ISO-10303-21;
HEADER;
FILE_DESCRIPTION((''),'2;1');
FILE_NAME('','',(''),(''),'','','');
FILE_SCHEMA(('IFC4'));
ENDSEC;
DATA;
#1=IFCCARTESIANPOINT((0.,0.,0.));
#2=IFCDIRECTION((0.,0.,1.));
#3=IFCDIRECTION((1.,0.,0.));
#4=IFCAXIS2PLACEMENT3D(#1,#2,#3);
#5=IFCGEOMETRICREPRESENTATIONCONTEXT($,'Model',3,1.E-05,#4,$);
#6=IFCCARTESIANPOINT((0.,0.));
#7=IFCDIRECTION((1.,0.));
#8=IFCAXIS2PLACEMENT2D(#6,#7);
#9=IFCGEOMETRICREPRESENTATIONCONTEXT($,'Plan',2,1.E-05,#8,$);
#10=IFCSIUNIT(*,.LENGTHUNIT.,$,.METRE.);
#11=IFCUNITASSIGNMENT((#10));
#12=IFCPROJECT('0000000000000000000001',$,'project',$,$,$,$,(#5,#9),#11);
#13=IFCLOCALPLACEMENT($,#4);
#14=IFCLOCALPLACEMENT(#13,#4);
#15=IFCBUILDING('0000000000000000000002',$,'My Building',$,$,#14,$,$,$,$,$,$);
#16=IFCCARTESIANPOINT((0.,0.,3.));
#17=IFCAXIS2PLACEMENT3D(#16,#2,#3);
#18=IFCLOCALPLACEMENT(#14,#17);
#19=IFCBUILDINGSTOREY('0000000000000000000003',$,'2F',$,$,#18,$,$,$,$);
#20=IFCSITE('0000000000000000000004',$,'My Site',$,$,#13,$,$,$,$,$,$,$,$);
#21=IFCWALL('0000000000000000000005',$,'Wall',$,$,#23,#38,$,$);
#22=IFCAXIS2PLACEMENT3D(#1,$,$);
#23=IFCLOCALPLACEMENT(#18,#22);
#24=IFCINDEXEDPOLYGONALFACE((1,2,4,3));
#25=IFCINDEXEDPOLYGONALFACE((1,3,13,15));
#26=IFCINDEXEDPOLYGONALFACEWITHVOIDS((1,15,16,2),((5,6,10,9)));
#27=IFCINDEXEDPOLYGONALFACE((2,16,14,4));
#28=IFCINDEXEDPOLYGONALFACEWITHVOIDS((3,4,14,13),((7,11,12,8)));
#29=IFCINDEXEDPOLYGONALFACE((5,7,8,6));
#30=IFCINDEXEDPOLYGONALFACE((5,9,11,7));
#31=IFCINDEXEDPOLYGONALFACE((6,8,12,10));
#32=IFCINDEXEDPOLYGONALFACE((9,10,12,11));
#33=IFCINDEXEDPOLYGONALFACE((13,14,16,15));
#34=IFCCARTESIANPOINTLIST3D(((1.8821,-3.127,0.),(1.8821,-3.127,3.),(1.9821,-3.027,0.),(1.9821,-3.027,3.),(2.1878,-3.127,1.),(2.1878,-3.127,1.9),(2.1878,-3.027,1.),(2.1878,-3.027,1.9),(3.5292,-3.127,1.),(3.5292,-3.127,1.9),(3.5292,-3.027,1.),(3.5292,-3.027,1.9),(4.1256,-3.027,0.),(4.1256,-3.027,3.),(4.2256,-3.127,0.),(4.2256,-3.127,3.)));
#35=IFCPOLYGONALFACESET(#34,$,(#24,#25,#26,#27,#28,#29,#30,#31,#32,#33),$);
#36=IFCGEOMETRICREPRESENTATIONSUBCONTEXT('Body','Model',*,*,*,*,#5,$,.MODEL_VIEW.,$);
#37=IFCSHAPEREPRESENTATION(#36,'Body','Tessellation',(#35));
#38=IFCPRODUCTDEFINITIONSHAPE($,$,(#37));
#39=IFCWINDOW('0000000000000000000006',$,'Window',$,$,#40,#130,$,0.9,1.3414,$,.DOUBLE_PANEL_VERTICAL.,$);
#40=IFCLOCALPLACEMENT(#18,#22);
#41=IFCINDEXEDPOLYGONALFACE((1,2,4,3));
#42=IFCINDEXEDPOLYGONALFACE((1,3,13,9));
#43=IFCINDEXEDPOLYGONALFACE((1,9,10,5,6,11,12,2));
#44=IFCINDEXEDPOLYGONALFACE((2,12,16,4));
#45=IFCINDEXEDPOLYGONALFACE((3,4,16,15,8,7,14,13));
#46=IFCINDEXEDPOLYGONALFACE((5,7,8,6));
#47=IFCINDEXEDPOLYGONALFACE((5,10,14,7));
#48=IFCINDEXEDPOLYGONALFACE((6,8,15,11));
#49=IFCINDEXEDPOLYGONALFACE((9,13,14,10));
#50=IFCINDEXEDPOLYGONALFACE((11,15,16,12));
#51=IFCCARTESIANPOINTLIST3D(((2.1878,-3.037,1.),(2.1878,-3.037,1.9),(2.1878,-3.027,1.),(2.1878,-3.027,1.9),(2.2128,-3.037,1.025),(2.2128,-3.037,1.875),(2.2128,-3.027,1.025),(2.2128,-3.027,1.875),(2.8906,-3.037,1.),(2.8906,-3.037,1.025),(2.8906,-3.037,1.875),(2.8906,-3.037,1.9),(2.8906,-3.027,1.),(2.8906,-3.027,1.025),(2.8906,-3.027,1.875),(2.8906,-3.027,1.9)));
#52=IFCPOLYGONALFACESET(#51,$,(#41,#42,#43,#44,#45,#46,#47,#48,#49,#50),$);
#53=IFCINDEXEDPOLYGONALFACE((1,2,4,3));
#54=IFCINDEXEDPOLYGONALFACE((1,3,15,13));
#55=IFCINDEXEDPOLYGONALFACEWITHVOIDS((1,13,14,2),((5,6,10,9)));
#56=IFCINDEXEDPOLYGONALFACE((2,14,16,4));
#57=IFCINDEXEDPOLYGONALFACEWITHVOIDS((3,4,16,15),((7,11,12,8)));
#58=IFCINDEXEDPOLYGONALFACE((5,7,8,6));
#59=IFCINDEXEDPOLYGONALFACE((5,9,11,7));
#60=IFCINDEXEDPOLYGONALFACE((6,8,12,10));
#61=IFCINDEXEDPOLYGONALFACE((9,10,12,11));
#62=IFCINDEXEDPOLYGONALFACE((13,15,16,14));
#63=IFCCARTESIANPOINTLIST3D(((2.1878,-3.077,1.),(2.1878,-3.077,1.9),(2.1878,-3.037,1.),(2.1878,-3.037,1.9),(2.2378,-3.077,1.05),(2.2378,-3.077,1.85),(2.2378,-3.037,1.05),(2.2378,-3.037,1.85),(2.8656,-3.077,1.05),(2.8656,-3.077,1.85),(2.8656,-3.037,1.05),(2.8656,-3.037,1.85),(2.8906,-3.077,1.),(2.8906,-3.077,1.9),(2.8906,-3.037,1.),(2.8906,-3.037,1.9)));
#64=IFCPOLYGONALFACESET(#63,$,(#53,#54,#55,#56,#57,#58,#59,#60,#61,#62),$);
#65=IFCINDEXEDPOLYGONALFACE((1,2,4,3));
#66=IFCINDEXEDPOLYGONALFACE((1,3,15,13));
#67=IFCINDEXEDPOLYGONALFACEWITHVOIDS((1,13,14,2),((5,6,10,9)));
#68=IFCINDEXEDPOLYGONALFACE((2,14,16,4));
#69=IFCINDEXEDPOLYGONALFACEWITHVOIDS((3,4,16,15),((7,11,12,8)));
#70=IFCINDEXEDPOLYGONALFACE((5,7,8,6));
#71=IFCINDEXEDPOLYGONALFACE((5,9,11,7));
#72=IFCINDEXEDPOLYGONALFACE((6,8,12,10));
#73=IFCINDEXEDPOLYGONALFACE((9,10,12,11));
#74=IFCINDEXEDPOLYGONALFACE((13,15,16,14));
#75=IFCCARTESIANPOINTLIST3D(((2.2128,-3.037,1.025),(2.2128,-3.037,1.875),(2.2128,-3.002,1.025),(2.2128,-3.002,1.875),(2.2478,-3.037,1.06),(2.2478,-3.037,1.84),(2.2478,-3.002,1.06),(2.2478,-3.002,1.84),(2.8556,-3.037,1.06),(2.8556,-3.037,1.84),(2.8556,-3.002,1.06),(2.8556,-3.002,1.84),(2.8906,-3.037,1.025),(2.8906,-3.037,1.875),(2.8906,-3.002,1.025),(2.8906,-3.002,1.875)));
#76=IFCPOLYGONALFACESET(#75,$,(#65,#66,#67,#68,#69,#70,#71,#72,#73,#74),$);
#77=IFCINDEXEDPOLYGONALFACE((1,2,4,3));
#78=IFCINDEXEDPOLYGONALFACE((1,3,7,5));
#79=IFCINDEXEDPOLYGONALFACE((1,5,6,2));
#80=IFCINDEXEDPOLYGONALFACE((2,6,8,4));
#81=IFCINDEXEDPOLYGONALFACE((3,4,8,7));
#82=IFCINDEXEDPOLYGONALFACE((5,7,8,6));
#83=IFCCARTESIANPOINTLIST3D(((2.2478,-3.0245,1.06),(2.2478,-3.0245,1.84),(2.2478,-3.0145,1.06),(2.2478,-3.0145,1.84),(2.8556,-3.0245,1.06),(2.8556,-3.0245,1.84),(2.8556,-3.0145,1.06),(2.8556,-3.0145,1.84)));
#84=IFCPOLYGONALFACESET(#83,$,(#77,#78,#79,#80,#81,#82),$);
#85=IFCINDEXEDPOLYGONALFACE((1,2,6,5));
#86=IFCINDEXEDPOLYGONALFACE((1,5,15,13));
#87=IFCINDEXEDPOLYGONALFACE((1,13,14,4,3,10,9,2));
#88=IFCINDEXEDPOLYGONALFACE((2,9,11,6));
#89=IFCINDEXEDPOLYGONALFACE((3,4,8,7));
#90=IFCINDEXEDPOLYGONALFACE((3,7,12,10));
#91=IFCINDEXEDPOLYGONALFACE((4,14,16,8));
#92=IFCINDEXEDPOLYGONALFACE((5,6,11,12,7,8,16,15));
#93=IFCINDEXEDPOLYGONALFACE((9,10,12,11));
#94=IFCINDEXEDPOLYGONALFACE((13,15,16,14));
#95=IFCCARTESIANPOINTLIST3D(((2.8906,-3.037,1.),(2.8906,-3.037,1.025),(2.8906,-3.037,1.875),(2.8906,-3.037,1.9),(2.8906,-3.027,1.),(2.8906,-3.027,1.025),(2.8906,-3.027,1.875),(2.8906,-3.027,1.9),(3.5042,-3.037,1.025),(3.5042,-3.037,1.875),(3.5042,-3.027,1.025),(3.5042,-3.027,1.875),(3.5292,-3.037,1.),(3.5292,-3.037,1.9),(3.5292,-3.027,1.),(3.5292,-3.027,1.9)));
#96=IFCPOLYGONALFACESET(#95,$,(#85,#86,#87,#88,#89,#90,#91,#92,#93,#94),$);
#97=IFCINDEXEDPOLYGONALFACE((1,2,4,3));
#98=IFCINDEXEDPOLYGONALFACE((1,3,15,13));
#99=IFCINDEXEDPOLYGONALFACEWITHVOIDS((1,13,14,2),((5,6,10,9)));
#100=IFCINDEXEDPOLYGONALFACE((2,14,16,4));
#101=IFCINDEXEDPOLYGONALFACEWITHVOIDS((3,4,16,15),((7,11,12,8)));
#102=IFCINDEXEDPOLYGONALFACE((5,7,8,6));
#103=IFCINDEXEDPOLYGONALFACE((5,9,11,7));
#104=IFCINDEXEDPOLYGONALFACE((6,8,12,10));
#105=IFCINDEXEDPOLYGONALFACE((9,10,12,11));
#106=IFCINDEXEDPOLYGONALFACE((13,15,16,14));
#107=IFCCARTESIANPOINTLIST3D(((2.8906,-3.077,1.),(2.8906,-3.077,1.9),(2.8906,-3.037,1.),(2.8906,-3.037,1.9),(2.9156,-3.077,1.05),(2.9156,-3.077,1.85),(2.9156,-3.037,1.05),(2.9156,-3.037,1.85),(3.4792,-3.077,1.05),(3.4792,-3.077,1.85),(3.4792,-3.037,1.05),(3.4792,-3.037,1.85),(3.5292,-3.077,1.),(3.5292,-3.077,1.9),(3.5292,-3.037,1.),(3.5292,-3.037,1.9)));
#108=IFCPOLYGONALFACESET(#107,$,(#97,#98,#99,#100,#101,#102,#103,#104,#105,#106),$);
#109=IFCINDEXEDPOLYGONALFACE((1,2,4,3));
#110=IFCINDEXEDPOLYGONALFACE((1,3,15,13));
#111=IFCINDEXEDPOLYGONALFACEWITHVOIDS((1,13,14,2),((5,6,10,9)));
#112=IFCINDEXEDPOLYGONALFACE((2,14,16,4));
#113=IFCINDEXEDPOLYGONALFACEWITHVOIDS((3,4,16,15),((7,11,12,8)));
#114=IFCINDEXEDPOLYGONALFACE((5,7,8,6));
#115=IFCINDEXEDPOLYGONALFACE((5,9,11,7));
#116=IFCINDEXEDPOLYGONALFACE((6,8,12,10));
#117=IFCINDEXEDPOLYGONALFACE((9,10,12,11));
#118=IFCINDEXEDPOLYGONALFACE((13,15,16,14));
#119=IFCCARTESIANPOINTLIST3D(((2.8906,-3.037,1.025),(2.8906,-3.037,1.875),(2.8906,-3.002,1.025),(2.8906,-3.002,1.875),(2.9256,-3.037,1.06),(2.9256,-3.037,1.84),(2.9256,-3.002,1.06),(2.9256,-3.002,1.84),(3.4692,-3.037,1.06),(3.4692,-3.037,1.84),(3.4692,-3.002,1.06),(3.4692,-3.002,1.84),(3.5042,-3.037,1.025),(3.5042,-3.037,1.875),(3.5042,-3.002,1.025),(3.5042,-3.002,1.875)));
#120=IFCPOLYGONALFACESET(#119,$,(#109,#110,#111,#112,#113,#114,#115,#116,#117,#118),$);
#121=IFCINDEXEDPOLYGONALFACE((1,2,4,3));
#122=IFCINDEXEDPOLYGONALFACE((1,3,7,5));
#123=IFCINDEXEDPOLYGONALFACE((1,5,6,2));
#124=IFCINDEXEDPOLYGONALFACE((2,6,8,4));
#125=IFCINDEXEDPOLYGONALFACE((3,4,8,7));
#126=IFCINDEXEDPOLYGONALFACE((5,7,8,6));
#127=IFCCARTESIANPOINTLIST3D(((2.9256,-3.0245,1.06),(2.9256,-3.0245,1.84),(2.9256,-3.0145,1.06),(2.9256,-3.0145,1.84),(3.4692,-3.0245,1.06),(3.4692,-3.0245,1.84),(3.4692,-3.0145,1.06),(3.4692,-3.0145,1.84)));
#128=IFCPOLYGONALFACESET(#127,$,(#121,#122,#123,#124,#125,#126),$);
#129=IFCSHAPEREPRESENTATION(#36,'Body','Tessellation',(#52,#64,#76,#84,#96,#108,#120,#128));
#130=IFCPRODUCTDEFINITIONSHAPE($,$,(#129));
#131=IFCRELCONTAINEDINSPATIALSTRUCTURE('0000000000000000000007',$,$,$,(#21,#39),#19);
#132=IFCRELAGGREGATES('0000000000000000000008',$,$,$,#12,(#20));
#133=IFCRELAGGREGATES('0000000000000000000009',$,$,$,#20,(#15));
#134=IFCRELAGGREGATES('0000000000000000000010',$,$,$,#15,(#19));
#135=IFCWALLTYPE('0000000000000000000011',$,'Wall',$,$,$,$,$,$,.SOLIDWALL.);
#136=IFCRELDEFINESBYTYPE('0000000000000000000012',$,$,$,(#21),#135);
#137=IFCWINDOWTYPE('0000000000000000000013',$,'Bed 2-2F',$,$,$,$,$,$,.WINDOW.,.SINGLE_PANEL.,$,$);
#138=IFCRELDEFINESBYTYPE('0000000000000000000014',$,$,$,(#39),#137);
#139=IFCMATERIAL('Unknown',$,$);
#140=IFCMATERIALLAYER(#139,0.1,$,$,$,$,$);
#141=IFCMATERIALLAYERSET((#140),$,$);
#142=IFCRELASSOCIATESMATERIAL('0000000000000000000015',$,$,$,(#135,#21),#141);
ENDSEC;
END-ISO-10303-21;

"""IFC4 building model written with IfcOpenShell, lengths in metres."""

from ifc_helpers import new_model, entity, si_unit, frame, origin_with_axes, origin_2d_with_axis, place, context, subcontext, project, spatial, line, indexed_curve, outline, extrude, shape, source, transform, mapped, material, layer, layer_set, layer_usage, type_object, type_shapes, element, fill, save


model = new_model("IFC4")

# Units and contexts
model_context = context("Model", 3, precision=1e-05, world=origin_with_axes())
plan_context = context("Plan", 2, precision=1e-05, world=origin_2d_with_axis())
body_context_1 = subcontext(model_context, "Body", "Model", "MODEL_VIEW")
body_context_2 = subcontext(plan_context, "Body", "Plan", "PLAN_VIEW")
ifc_project = project(units=[si_unit("LENGTHUNIT", "METRE")], contexts=[model_context, plan_context])

# Site, building, storey
site_placement = place(None, origin_with_axes())
site = spatial("IfcSite", under=ifc_project, at=site_placement, Name="My Site")
building_placement = place(site_placement, origin_with_axes())
building = spatial("IfcBuilding", under=site, at=building_placement, Name="My Building")
storey_placement = place(building_placement, frame((0.0, 0.0, 3.0), z_axis=(0.0, 0.0, 1.0), x_axis=(1.0, 0.0, 0.0)))
storey = spatial("IfcBuildingStorey", under=building, at=storey_placement, Name="2F")

# Shared definitions
ifc_material = material(Name="Unknown")
ifc_layer = layer(ifc_material, 0.1)
ifc_layer_set = layer_set([ifc_layer])
wall_type = type_object("IfcWallType", Name="Wall", PredefinedType="SOLIDWALL", material=ifc_layer_set)

# Wall, opening, window
ifc_layer_usage_1 = layer_usage(ifc_layer_set, "AXIS2", "POSITIVE", 0.0)
wall_1_placement = place(storey_placement, frame((1.8821, -3.127, 0.0), z_axis=(0.0, 0.0, 1.0), x_axis=(1.0, 0.0, 0.0)))
wall_1 = element("IfcWall", 1, at=wall_1_placement, inside=storey, type_object=wall_type, material=ifc_layer_usage_1, Name="Wall", context=body_context_1, shape_type="SweptSolid", body=[
    extrude(outline(indexed_curve([(0.0, 0.0), (0.1, 0.1), (2.2435, 0.1), (2.3435, 0.0)], segments=[line(1, 2, 3, 4, 1)])), origin_with_axes(), (0.0, 0.0, 1.0), 3.0),
])
shared_shape_1 = source(origin_with_axes(), body_context_1, "Body", "SweptSolid", [
    extrude(outline(indexed_curve([(0.0, 0.0), (1.3414, 0.0), (1.3414, 0.9), (0.0, 0.9)], segments=[line(1, 2, 3, 4, 1)])), frame((0.0, -0.6, 0.0), z_axis=(0.0, -1.0, 0.0), x_axis=(1.0, 0.0, 0.0)), (0.0, 0.0, -1.0), 1.2),
])
opening_1_placement = place(wall_1_placement, frame((0.3057, 0.0, 1.0), z_axis=(0.0, 0.0, 1.0), x_axis=(1.0, 0.0, 0.0)))
opening_1 = element("IfcOpeningElement", 2, at=opening_1_placement, cuts=wall_1, PredefinedType="OPENING", context=body_context_1, shape_type="MappedRepresentation", body=[
    mapped(shared_shape_1, transform((0.0, 0.0, 0.0), x_axis=(1.0, 0.0, 0.0), y_axis=(0.0, 1.0, 0.0), z_axis=(0.0, 0.0, 1.0), scale=1.0)),
])
window_type_1 = type_object("IfcWindowType", Name="Bed 2-2F", PartitioningType="SINGLE_PANEL", PredefinedType="WINDOW")
shared_shape_2 = source(origin_with_axes(), body_context_1, "Body", "SweptSolid", [
    extrude(outline(indexed_curve([(0.7028, 0.0), (0.0, 0.0), (0.0, 0.9), (0.7028, 0.9), (0.7028, 0.875), (0.025, 0.875), (0.025, 0.025), (0.7028, 0.025)], segments=[line(1, 2, 3, 4, 5, 6, 7, 8, 1)])), frame((0.0, 0.09, 0.0), z_axis=(0.0, -1.0, 0.0), x_axis=(1.0, 0.0, 0.0)), (0.0, 0.0, -1.0), 0.01),
    extrude(outline(indexed_curve([(0.0, 0.0), (0.7028, 0.0), (0.7028, 0.9), (0.0, 0.9)], segments=[line(1, 2, 3, 4, 1)]), holes=[indexed_curve([(0.05, 0.05), (0.6778, 0.05), (0.6778, 0.85), (0.05, 0.85)], segments=[line(1, 2, 3, 4, 1)])]), frame((0.0, 0.05, 0.0), z_axis=(0.0, -1.0, 0.0), x_axis=(1.0, 0.0, 0.0)), (0.0, 0.0, -1.0), 0.04),
    extrude(outline(indexed_curve([(0.0, 0.0), (0.6778, 0.0), (0.6778, 0.85), (0.0, 0.85)], segments=[line(1, 2, 3, 4, 1)]), holes=[indexed_curve([(0.035, 0.035), (0.6428, 0.035), (0.6428, 0.815), (0.035, 0.815)], segments=[line(1, 2, 3, 4, 1)])]), frame((0.025, 0.09, 0.025), z_axis=(0.0, -1.0, 0.0), x_axis=(1.0, 0.0, 0.0)), (0.0, 0.0, -1.0), 0.035),
    extrude(outline(indexed_curve([(0.035, 0.035), (0.6428, 0.035), (0.6428, 0.815), (0.035, 0.815)], segments=[line(1, 2, 3, 4, 1)])), frame((0.025, 0.1025, 0.025), z_axis=(0.0, -1.0, 0.0), x_axis=(1.0, 0.0, 0.0)), (0.0, 0.0, -1.0), 0.01),
    extrude(outline(indexed_curve([(0.0, 0.9), (0.6386, 0.9), (0.6386, 0.0), (0.0, 0.0), (0.0, 0.025), (0.6136, 0.025), (0.6136, 0.875), (0.0, 0.875)], segments=[line(1, 2, 3, 4, 5, 6, 7, 8, 1)])), frame((0.7028, 0.09, 0.0), z_axis=(0.0, -1.0, 0.0), x_axis=(1.0, 0.0, 0.0)), (0.0, 0.0, -1.0), 0.01),
    extrude(outline(indexed_curve([(0.0, 0.0), (0.6386, 0.0), (0.6386, 0.9), (0.0, 0.9)], segments=[line(1, 2, 3, 4, 1)]), holes=[indexed_curve([(0.025, 0.05), (0.5886, 0.05), (0.5886, 0.85), (0.025, 0.85)], segments=[line(1, 2, 3, 4, 1)])]), frame((0.7028, 0.05, 0.0), z_axis=(0.0, -1.0, 0.0), x_axis=(1.0, 0.0, 0.0)), (0.0, 0.0, -1.0), 0.04),
    extrude(outline(indexed_curve([(0.0, 0.0), (0.6136, 0.0), (0.6136, 0.85), (0.0, 0.85)], segments=[line(1, 2, 3, 4, 1)]), holes=[indexed_curve([(0.035, 0.035), (0.5786, 0.035), (0.5786, 0.815), (0.035, 0.815)], segments=[line(1, 2, 3, 4, 1)])]), frame((0.7028, 0.09, 0.025), z_axis=(0.0, -1.0, 0.0), x_axis=(1.0, 0.0, 0.0)), (0.0, 0.0, -1.0), 0.035),
    extrude(outline(indexed_curve([(0.035, 0.035), (0.5786, 0.035), (0.5786, 0.815), (0.035, 0.815)], segments=[line(1, 2, 3, 4, 1)])), frame((0.7028, 0.1025, 0.025), z_axis=(0.0, -1.0, 0.0), x_axis=(1.0, 0.0, 0.0)), (0.0, 0.0, -1.0), 0.01),
])
shared_shape_3 = source(origin_with_axes(), body_context_2, "Body", "Curve2D", [
    entity("IfcIndexedPolyCurve", entity("IfcCartesianPointList2D", [[0.05, 0.05], [0.6778, 0.05]])),
    entity("IfcIndexedPolyCurve", entity("IfcCartesianPointList2D", [[0.0, 0.1], [0.025, 0.1], [0.025, 0.09], [0.05, 0.09], [0.05, 0.05], [0.0, 0.05]]), [entity("IfcLineIndex", [1, 2, 3, 4, 5, 6, 1])]),
    entity("IfcIndexedPolyCurve", entity("IfcCartesianPointList2D", [[0.7028, 0.1], [0.7028, 0.1], [0.7028, 0.09], [0.6778, 0.09], [0.6778, 0.05], [0.7028, 0.05]])),
    entity("IfcIndexedPolyCurve", entity("IfcCartesianPointList2D", [[0.025, 0.09], [0.06, 0.09], [0.06, 0.125], [0.025, 0.125]]), [entity("IfcLineIndex", [1, 2, 3, 4, 1])]),
    entity("IfcIndexedPolyCurve", entity("IfcCartesianPointList2D", [[0.7028, 0.09], [0.6678, 0.09], [0.6678, 0.125], [0.7028, 0.125]]), [entity("IfcLineIndex", [1, 2, 3, 4, 1])]),
    entity("IfcIndexedPolyCurve", entity("IfcCartesianPointList2D", [[0.06, 0.09], [0.6678, 0.09]])),
    entity("IfcIndexedPolyCurve", entity("IfcCartesianPointList2D", [[0.06, 0.125], [0.6678, 0.125]])),
    entity("IfcIndexedPolyCurve", entity("IfcCartesianPointList2D", [[0.06, 0.1075], [0.6678, 0.1075]])),
    entity("IfcIndexedPolyCurve", entity("IfcCartesianPointList2D", [[0.7278, 0.05], [1.2914, 0.05]])),
    entity("IfcIndexedPolyCurve", entity("IfcCartesianPointList2D", [[0.7028, 0.1], [0.7028, 0.1], [0.7028, 0.09], [0.7278, 0.09], [0.7278, 0.05], [0.7028, 0.05]])),
    entity("IfcIndexedPolyCurve", entity("IfcCartesianPointList2D", [[1.3414, 0.1], [1.3164, 0.1], [1.3164, 0.09], [1.2914, 0.09], [1.2914, 0.05], [1.3414, 0.05]]), [entity("IfcLineIndex", [1, 2, 3, 4, 5, 6, 1])]),
    entity("IfcIndexedPolyCurve", entity("IfcCartesianPointList2D", [[0.7028, 0.09], [0.7378, 0.09], [0.7378, 0.125], [0.7028, 0.125]]), [entity("IfcLineIndex", [1, 2, 3, 4, 1])]),
    entity("IfcIndexedPolyCurve", entity("IfcCartesianPointList2D", [[1.3164, 0.09], [1.2814, 0.09], [1.2814, 0.125], [1.3164, 0.125]]), [entity("IfcLineIndex", [1, 2, 3, 4, 1])]),
    entity("IfcIndexedPolyCurve", entity("IfcCartesianPointList2D", [[0.7378, 0.09], [1.2814, 0.09]])),
    entity("IfcIndexedPolyCurve", entity("IfcCartesianPointList2D", [[0.7378, 0.125], [1.2814, 0.125]])),
    entity("IfcIndexedPolyCurve", entity("IfcCartesianPointList2D", [[0.7378, 0.1075], [1.2814, 0.1075]])),
])
type_shapes(window_type_1, [shared_shape_2, shared_shape_3])
window_1_placement = place(opening_1_placement, origin_with_axes())
window_1 = element("IfcWindow", 3, at=window_1_placement, inside=storey, type_object=window_type_1, Name="Window", OverallHeight=0.9, OverallWidth=1.3414, PartitioningType="DOUBLE_PANEL_VERTICAL", shapes=[
    shape(body_context_1, "Body", "MappedRepresentation", [mapped(shared_shape_2, transform((0.0, 0.0, 0.0), x_axis=(1.0, 0.0, 0.0), y_axis=(0.0, 1.0, 0.0), z_axis=(0.0, 0.0, 1.0), scale=1.0))]),
    shape(body_context_2, "Body", "MappedRepresentation", [mapped(shared_shape_3, transform((0.0, 0.0, 0.0), x_axis=(1.0, 0.0, 0.0), y_axis=(0.0, 1.0, 0.0), z_axis=(0.0, 0.0, 1.0), scale=1.0))]),
])
fill(opening_1, window_1)

save(model, "model.ifc")
